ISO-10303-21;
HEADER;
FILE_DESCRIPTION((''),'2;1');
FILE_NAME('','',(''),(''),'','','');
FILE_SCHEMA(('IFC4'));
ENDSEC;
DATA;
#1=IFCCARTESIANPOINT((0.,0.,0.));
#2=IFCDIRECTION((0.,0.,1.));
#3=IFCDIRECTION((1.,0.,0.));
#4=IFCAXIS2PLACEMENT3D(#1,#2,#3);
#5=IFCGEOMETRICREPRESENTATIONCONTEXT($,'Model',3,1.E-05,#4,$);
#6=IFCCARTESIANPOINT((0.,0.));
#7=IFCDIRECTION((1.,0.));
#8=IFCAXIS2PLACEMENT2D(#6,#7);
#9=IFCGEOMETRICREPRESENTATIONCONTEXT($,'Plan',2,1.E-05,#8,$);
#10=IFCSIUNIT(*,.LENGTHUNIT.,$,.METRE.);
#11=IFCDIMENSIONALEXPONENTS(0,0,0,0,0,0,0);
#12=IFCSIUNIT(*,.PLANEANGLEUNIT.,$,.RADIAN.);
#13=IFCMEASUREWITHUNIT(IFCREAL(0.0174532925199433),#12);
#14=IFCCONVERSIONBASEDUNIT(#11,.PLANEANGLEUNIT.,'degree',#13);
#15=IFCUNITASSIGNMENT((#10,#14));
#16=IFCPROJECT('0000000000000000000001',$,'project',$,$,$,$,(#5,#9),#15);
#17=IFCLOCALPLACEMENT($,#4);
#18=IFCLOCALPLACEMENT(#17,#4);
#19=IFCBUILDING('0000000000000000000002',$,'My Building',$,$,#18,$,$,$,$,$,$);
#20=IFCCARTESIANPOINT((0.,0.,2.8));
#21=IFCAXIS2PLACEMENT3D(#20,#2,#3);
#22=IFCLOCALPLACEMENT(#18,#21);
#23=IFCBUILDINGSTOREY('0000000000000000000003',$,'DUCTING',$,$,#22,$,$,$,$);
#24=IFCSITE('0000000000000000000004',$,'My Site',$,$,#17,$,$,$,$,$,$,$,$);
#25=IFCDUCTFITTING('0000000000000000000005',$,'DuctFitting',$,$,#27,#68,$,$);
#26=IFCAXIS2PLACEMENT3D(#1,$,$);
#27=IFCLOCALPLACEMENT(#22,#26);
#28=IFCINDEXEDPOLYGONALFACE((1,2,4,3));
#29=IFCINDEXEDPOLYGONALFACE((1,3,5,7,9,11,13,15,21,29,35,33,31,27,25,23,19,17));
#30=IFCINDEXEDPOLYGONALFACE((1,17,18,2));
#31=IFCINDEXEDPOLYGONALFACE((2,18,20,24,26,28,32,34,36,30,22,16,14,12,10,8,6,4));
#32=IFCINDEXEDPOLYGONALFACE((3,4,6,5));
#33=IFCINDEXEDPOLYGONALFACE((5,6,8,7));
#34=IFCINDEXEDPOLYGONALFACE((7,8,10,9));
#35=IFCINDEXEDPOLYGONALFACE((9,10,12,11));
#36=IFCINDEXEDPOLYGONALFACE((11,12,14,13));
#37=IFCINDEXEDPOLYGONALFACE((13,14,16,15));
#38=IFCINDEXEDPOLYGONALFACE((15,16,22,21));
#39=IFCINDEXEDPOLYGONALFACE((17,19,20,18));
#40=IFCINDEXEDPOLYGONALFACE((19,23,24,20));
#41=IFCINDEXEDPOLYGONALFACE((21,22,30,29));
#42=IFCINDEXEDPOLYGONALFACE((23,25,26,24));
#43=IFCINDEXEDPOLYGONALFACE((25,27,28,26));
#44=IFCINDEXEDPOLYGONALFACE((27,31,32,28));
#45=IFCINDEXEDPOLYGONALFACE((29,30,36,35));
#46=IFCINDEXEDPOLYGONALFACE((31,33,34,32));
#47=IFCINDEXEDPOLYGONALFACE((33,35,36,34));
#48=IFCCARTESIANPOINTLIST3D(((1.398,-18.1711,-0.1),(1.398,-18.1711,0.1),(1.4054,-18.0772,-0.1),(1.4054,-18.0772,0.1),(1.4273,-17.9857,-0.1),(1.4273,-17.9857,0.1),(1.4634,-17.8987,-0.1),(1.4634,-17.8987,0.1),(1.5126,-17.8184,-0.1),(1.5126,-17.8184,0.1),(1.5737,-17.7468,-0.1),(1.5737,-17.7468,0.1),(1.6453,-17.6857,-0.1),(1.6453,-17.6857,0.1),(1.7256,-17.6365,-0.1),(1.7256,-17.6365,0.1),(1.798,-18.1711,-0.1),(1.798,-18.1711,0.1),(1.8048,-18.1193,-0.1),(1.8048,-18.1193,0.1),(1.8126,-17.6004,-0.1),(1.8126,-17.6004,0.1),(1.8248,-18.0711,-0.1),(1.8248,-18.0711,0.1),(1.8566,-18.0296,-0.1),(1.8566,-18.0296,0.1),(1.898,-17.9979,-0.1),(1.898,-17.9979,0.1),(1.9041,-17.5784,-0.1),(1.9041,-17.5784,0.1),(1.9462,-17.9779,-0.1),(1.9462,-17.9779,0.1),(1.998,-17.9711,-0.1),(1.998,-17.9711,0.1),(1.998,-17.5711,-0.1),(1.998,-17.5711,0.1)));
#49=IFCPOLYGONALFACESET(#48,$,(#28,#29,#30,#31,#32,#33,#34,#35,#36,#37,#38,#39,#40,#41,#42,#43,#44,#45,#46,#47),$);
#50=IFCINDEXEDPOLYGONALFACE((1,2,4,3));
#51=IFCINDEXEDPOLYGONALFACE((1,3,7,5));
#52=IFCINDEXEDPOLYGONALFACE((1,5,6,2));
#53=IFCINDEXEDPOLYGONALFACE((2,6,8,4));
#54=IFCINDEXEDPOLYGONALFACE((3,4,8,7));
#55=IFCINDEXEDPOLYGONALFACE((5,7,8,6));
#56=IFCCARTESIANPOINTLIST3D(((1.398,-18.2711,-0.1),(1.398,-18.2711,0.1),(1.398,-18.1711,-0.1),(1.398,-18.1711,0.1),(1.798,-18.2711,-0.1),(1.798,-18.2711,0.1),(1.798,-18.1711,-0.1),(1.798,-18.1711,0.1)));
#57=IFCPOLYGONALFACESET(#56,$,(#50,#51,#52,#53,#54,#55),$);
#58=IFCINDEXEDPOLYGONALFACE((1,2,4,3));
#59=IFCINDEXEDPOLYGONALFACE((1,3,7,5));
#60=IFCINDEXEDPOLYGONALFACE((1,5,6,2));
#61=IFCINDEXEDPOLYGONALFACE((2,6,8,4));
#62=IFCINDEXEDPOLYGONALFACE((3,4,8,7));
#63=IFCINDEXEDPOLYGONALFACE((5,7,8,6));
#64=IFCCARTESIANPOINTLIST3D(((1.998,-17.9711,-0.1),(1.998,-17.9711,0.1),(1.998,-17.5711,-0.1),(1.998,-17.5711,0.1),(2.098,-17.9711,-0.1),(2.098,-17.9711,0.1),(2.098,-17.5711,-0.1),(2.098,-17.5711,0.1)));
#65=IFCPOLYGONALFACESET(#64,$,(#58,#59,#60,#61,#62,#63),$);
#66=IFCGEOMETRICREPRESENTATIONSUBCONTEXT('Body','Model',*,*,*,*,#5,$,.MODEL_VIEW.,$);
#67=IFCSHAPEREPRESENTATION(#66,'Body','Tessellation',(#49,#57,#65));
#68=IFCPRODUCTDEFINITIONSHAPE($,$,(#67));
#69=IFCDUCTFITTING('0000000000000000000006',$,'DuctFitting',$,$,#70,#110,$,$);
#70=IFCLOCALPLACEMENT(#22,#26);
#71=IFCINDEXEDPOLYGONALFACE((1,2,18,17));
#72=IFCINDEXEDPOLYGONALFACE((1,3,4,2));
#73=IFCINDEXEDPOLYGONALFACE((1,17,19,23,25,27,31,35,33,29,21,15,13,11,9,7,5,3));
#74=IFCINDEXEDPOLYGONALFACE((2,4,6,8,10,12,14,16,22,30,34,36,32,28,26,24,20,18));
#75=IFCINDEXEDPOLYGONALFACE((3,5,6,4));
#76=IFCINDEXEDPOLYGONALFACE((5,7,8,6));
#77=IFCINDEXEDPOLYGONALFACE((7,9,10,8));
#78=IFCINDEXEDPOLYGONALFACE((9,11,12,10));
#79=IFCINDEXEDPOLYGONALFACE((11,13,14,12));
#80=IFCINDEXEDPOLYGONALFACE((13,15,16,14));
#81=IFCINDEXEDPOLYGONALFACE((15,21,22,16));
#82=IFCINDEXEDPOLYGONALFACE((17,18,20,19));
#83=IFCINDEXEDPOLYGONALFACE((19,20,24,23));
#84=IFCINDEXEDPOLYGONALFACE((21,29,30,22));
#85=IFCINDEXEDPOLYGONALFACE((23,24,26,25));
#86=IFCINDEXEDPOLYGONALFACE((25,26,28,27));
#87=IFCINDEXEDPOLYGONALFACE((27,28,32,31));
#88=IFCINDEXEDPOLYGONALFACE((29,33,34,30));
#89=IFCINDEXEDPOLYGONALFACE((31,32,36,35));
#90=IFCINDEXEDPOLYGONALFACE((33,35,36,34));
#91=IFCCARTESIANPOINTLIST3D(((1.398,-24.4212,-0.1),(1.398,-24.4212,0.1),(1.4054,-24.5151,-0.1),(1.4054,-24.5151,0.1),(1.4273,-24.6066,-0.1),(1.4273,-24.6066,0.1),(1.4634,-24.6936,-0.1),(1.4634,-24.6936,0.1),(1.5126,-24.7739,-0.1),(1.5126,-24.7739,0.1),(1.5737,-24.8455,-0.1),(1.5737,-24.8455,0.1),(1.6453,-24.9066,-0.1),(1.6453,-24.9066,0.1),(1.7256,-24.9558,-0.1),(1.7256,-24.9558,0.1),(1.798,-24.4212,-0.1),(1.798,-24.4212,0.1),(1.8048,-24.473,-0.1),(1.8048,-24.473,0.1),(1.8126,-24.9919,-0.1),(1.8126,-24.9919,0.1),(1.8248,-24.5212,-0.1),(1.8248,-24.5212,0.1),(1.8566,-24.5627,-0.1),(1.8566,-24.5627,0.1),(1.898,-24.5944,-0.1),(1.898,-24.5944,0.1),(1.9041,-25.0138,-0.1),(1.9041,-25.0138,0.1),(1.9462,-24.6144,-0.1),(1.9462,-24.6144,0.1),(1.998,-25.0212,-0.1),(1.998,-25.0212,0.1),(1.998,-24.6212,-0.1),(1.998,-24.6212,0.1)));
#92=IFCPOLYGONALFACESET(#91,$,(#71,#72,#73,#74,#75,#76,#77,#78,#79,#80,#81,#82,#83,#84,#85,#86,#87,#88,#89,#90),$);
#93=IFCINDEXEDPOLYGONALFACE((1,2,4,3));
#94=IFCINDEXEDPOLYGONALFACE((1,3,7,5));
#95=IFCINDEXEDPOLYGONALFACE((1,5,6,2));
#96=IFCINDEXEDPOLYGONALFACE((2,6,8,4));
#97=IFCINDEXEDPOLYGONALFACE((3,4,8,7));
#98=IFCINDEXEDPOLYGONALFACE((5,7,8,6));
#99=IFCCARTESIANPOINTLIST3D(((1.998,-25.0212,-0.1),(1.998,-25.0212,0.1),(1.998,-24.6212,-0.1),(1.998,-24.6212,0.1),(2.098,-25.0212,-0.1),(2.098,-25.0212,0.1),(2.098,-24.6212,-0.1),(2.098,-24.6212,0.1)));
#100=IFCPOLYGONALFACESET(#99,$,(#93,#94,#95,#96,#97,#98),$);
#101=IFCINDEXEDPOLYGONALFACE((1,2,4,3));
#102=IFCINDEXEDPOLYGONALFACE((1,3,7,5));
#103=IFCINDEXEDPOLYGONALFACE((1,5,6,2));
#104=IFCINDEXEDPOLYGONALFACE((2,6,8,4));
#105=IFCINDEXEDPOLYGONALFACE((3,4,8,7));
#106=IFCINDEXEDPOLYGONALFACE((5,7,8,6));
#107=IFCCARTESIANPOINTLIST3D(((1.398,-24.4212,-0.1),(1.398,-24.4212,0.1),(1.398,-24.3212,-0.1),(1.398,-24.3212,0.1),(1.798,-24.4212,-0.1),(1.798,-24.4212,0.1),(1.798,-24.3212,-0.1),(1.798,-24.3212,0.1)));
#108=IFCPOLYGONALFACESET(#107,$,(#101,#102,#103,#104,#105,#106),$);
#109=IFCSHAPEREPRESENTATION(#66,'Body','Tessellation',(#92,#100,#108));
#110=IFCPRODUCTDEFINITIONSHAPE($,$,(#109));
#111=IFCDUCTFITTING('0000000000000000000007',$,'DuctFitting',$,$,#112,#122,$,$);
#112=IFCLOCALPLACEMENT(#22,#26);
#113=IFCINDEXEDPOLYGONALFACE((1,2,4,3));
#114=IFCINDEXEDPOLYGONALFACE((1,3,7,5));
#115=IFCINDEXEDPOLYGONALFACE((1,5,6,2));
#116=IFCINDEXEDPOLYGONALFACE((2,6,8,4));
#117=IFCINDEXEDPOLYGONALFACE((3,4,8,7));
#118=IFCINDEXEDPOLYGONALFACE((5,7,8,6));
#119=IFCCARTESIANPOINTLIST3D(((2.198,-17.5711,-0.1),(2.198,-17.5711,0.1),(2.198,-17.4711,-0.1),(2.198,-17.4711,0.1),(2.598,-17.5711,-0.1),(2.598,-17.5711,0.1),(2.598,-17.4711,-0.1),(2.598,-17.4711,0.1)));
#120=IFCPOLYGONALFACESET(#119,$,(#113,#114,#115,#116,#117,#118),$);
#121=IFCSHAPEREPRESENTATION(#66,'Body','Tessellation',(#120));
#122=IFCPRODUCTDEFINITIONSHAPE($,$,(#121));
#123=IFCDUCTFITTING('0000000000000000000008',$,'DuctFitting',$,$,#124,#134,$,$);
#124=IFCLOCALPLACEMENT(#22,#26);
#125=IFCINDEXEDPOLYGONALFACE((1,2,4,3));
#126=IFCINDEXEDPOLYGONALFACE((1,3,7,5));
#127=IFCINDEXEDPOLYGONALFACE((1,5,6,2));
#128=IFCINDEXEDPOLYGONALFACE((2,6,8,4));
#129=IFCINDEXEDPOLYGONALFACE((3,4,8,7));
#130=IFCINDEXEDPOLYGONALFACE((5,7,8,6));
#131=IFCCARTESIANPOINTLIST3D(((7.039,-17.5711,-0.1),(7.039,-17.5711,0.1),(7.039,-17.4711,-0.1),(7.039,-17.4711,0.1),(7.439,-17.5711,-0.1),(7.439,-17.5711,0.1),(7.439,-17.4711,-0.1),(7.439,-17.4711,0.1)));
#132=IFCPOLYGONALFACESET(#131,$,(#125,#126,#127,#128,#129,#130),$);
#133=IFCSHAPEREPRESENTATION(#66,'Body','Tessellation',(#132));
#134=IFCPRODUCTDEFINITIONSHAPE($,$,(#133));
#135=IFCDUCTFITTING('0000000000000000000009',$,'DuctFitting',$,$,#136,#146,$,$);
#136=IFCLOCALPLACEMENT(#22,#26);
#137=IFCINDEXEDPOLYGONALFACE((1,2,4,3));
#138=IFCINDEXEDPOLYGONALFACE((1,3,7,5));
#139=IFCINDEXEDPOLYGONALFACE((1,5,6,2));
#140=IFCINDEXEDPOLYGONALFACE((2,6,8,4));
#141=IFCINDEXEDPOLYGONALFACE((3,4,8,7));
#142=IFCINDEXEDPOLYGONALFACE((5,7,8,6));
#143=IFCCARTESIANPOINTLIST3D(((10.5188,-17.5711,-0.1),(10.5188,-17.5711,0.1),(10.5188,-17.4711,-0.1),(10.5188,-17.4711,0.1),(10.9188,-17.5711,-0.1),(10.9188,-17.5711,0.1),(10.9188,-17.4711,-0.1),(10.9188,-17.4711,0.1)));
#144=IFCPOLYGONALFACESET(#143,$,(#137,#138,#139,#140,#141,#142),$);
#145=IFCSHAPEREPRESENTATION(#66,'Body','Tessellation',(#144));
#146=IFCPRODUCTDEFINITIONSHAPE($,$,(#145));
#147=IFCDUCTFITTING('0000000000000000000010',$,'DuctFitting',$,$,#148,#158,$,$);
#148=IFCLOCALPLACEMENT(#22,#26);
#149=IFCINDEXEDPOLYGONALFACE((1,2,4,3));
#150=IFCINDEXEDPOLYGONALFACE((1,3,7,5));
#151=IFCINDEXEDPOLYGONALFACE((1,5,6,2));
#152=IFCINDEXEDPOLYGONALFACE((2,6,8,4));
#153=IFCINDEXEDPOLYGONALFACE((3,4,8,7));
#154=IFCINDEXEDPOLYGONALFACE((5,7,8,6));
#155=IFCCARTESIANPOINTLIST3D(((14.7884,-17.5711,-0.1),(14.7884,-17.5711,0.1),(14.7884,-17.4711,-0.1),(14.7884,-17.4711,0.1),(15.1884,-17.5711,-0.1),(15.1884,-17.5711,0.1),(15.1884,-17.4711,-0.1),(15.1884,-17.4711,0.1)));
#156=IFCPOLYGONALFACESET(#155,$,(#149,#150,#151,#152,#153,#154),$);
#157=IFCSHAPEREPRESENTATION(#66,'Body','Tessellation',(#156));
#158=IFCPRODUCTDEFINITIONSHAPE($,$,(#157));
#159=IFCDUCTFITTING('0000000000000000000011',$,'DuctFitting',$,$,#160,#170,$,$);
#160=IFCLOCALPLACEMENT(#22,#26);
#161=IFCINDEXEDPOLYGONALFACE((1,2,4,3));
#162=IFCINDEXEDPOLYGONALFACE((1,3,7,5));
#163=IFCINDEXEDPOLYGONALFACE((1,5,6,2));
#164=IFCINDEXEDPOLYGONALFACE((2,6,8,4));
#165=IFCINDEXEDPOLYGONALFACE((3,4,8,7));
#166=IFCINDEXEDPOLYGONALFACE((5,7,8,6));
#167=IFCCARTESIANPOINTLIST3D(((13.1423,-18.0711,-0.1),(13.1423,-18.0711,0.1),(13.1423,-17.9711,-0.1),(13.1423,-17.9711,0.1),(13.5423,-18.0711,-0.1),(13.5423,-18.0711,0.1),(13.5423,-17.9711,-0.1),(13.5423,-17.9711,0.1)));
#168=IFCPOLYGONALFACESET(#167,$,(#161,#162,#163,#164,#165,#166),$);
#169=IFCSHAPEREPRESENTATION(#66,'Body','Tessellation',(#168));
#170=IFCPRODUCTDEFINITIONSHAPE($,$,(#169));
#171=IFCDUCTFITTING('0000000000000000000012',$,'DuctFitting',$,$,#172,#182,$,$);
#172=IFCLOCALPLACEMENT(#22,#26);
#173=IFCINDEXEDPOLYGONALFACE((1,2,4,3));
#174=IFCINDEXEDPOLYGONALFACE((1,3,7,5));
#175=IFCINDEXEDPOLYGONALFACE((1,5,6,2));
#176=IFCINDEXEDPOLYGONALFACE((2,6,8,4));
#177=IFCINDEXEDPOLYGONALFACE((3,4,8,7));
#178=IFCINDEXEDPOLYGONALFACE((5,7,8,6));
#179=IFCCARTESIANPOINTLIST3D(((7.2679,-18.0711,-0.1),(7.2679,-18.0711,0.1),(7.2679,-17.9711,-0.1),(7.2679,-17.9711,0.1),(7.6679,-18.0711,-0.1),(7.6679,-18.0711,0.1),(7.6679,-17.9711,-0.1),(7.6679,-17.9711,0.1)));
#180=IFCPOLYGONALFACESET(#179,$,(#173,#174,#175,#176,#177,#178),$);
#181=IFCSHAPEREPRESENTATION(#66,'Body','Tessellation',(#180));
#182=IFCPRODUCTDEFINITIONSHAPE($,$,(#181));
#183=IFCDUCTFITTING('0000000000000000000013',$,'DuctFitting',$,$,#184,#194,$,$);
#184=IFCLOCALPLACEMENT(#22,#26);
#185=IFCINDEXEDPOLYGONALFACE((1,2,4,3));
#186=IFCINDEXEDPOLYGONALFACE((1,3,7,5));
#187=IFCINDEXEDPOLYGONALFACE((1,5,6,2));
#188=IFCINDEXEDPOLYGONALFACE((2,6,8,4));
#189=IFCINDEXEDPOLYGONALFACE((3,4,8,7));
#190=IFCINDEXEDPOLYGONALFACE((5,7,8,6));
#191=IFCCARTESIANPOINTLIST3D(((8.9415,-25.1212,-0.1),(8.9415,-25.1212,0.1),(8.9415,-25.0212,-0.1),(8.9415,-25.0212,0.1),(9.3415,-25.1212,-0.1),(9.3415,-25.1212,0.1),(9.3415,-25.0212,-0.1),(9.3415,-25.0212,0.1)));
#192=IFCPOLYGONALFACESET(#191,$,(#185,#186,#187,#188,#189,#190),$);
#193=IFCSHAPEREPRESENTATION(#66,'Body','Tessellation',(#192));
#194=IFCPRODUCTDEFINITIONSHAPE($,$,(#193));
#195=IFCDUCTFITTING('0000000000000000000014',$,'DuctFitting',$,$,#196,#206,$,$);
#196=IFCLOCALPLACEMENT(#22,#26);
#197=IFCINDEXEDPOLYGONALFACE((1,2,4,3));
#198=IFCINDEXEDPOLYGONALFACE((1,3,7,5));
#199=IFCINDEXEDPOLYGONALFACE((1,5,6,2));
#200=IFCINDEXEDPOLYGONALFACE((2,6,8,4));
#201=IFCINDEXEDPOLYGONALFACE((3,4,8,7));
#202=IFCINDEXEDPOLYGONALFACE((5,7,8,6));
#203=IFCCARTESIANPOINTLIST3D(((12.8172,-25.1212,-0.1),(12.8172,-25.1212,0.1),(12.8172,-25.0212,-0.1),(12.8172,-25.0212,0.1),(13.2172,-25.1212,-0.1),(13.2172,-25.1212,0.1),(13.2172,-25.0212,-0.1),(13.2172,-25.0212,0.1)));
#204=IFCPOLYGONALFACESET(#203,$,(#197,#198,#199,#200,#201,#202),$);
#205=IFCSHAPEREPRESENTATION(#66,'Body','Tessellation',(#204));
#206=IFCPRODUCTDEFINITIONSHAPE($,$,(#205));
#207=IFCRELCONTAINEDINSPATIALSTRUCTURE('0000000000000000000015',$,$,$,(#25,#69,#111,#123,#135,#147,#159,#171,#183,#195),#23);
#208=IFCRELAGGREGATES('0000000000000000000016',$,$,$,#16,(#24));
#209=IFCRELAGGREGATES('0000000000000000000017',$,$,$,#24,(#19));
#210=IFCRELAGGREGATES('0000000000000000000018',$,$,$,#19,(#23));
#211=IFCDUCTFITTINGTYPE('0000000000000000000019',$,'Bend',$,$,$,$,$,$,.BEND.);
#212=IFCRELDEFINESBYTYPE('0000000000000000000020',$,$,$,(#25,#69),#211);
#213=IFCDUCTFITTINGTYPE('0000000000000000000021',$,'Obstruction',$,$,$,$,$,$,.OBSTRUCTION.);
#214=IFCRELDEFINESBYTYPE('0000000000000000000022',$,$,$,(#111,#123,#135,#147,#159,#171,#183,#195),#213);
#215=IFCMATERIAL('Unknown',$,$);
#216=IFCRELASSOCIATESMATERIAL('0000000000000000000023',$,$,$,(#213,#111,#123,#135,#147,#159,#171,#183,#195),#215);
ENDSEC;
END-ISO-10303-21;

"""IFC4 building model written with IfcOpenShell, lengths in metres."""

from ifc_helpers import new_model, entity, si_unit, converted_unit, frame, origin_with_axes, origin_2d_with_axis, place, context, subcontext, project, spatial, line, arc, indexed_curve, rectangle, outline, extrude, source, transform, mapped, material, material_profile, profile_set, profile_usage, type_object, type_shapes, element, save


model = new_model("IFC4")

# Units and contexts
model_context = context("Model", 3, precision=1e-05, world=origin_with_axes())
plan_context = context("Plan", 2, precision=1e-05, world=origin_2d_with_axis())
body_context = subcontext(model_context, "Body", "Model", "MODEL_VIEW")
ifc_project = project(units=[si_unit("LENGTHUNIT", "METRE"), converted_unit("PLANEANGLEUNIT", "degree", entity("IfcReal", 0.0174532925199433), si_unit("PLANEANGLEUNIT", "RADIAN"), dimensions=[0, 0, 0, 0, 0, 0, 0])], contexts=[model_context, plan_context])

# Site, building, storey
site_placement = place(None, origin_with_axes())
site = spatial("IfcSite", under=ifc_project, at=site_placement, Name="My Site")
building_placement = place(site_placement, origin_with_axes())
building = spatial("IfcBuilding", under=site, at=building_placement, Name="My Building")
storey_placement = place(building_placement, frame((0.0, 0.0, 2.8), z_axis=(0.0, 0.0, 1.0), x_axis=(1.0, 0.0, 0.0)))
storey = spatial("IfcBuildingStorey", under=building, at=storey_placement, Name="DUCTING")

# Shared definitions
ifc_material = material(Name="Unknown")

# Duct fittings
duct_fitting_type_1 = type_object("IfcDuctFittingType", Name="Bend", PredefinedType="BEND")
shared_shape = source(origin_with_axes(), body_context, "Body", "SweptSolid", [
    extrude(outline(indexed_curve([(-0.2, 0.0), (-0.2586, -0.1414), (-0.4, -0.2), (-0.4, -0.6), (0.0243, -0.4243), (0.2, 0.0)], segments=[arc(1, 2, 3), line(3, 4), arc(4, 5, 6), line(6, 1)])), frame((0.0, -0.1, -0.1), z_axis=(0.0, -1.0, 0.0), x_axis=(1.0, 0.0, 0.0)), (0.0, 0.0, -1.0), 0.2),
    extrude(rectangle(XDim=0.4, YDim=0.2), origin_with_axes(), (0.0, 0.0, -1.0), 0.1),
    extrude(rectangle(XDim=0.4, YDim=0.2), frame((-0.4, 0.0, -0.5), z_axis=(-1.0, 0.0, 0.0), x_axis=(0.0, 0.0, -1.0)), (0.0, 0.0, 1.0), 0.1),
])
type_shapes(duct_fitting_type_1, [shared_shape])
for number, where, z_axis, x_axis, name in (
    (1, (1.598, -18.2711, 0.0), (0.0, -1.0, 0.0), (-1.0, 0.0, 0.0), "DuctFitting"),
    (2, (2.098, -24.8212, 0.0), (1.0, 0.0, 0.0), (0.0, -1.0, 0.0), "DuctFitting"),
):
    element("IfcDuctFitting", number, at=place(storey_placement, frame(where, z_axis=z_axis, x_axis=x_axis)), inside=storey, type_object=duct_fitting_type_1, Name=name, context=body_context, shape_type="MappedRepresentation", body=[
        mapped(shared_shape, transform((0.0, 0.0, 0.0), x_axis=(1.0, 0.0, 0.0), y_axis=(0.0, 1.0, 0.0), z_axis=(0.0, 0.0, 1.0), scale=1.0)),
    ])
ifc_material_profile_1 = material_profile(ifc_material, rectangle(XDim=0.4, YDim=0.2))
ifc_profile_set_1 = profile_set([ifc_material_profile_1])
ifc_profile_usage_1 = profile_usage(ifc_profile_set_1, cardinal=5)
duct_fitting_type_2 = type_object("IfcDuctFittingType", Name="Obstruction", PredefinedType="OBSTRUCTION", material=ifc_profile_set_1)
duct_fitting_1_placement = place(storey_placement, frame((2.398, -17.4711, 0.0), z_axis=(0.0, -1.0, 0.0), x_axis=(1.0, 0.0, 0.0)))
element("IfcDuctFitting", 3, at=duct_fitting_1_placement, inside=storey, type_object=duct_fitting_type_2, material=ifc_profile_usage_1, Name="DuctFitting", context=body_context, shape_type="SweptSolid", body=[
    extrude(rectangle(XDim=0.4, YDim=0.2), origin_with_axes(), (0.0, 0.0, 1.0), 0.1),
])
ifc_profile_usage_2 = profile_usage(ifc_profile_set_1, cardinal=5)
duct_fitting_2_placement = place(storey_placement, frame((7.239, -17.4711, 0.0), z_axis=(0.0, -1.0, 0.0), x_axis=(1.0, 0.0, 0.0)))
element("IfcDuctFitting", 4, at=duct_fitting_2_placement, inside=storey, type_object=duct_fitting_type_2, material=ifc_profile_usage_2, Name="DuctFitting", context=body_context, shape_type="SweptSolid", body=[
    extrude(rectangle(XDim=0.4, YDim=0.2), origin_with_axes(), (0.0, 0.0, 1.0), 0.1),
])
ifc_profile_usage_3 = profile_usage(ifc_profile_set_1, cardinal=5)
duct_fitting_3_placement = place(storey_placement, frame((10.7188, -17.4711, 0.0), z_axis=(0.0, -1.0, 0.0), x_axis=(1.0, 0.0, 0.0)))
element("IfcDuctFitting", 5, at=duct_fitting_3_placement, inside=storey, type_object=duct_fitting_type_2, material=ifc_profile_usage_3, Name="DuctFitting", context=body_context, shape_type="SweptSolid", body=[
    extrude(rectangle(XDim=0.4, YDim=0.2), origin_with_axes(), (0.0, 0.0, 1.0), 0.1),
])
ifc_profile_usage_4 = profile_usage(ifc_profile_set_1, cardinal=5)
duct_fitting_4_placement = place(storey_placement, frame((14.9884, -17.4711, 0.0), z_axis=(0.0, -1.0, 0.0), x_axis=(1.0, 0.0, 0.0)))
element("IfcDuctFitting", 6, at=duct_fitting_4_placement, inside=storey, type_object=duct_fitting_type_2, material=ifc_profile_usage_4, Name="DuctFitting", context=body_context, shape_type="SweptSolid", body=[
    extrude(rectangle(XDim=0.4, YDim=0.2), origin_with_axes(), (0.0, 0.0, 1.0), 0.1),
])
ifc_profile_usage_5 = profile_usage(ifc_profile_set_1, cardinal=5)
duct_fitting_5_placement = place(storey_placement, frame((13.3423, -18.0711, 0.0), z_axis=(0.0, 1.0, 0.0), x_axis=(-1.0, 0.0, 0.0)))
element("IfcDuctFitting", 7, at=duct_fitting_5_placement, inside=storey, type_object=duct_fitting_type_2, material=ifc_profile_usage_5, Name="DuctFitting", context=body_context, shape_type="SweptSolid", body=[
    extrude(rectangle(XDim=0.4, YDim=0.2), origin_with_axes(), (0.0, 0.0, 1.0), 0.1),
])
ifc_profile_usage_6 = profile_usage(ifc_profile_set_1, cardinal=5)
duct_fitting_6_placement = place(storey_placement, frame((7.4679, -18.0711, 0.0), z_axis=(0.0, 1.0, 0.0), x_axis=(-1.0, 0.0, 0.0)))
element("IfcDuctFitting", 8, at=duct_fitting_6_placement, inside=storey, type_object=duct_fitting_type_2, material=ifc_profile_usage_6, Name="DuctFitting", context=body_context, shape_type="SweptSolid", body=[
    extrude(rectangle(XDim=0.4, YDim=0.2), origin_with_axes(), (0.0, 0.0, 1.0), 0.1),
])
ifc_profile_usage_7 = profile_usage(ifc_profile_set_1, cardinal=5)
duct_fitting_7_placement = place(storey_placement, frame((9.1415, -25.1212, 0.0), z_axis=(0.0, 1.0, 0.0), x_axis=(-1.0, 0.0, 0.0)))
element("IfcDuctFitting", 9, at=duct_fitting_7_placement, inside=storey, type_object=duct_fitting_type_2, material=ifc_profile_usage_7, Name="DuctFitting", context=body_context, shape_type="SweptSolid", body=[
    extrude(rectangle(XDim=0.4, YDim=0.2), origin_with_axes(), (0.0, 0.0, 1.0), 0.1),
])
ifc_profile_usage_8 = profile_usage(ifc_profile_set_1, cardinal=5)
duct_fitting_8_placement = place(storey_placement, frame((13.0172, -25.1212, 0.0), z_axis=(0.0, 1.0, 0.0), x_axis=(-1.0, 0.0, 0.0)))
element("IfcDuctFitting", 10, at=duct_fitting_8_placement, inside=storey, type_object=duct_fitting_type_2, material=ifc_profile_usage_8, Name="DuctFitting", context=body_context, shape_type="SweptSolid", body=[
    extrude(rectangle(XDim=0.4, YDim=0.2), origin_with_axes(), (0.0, 0.0, 1.0), 0.1),
])

save(model, "model.ifc")
